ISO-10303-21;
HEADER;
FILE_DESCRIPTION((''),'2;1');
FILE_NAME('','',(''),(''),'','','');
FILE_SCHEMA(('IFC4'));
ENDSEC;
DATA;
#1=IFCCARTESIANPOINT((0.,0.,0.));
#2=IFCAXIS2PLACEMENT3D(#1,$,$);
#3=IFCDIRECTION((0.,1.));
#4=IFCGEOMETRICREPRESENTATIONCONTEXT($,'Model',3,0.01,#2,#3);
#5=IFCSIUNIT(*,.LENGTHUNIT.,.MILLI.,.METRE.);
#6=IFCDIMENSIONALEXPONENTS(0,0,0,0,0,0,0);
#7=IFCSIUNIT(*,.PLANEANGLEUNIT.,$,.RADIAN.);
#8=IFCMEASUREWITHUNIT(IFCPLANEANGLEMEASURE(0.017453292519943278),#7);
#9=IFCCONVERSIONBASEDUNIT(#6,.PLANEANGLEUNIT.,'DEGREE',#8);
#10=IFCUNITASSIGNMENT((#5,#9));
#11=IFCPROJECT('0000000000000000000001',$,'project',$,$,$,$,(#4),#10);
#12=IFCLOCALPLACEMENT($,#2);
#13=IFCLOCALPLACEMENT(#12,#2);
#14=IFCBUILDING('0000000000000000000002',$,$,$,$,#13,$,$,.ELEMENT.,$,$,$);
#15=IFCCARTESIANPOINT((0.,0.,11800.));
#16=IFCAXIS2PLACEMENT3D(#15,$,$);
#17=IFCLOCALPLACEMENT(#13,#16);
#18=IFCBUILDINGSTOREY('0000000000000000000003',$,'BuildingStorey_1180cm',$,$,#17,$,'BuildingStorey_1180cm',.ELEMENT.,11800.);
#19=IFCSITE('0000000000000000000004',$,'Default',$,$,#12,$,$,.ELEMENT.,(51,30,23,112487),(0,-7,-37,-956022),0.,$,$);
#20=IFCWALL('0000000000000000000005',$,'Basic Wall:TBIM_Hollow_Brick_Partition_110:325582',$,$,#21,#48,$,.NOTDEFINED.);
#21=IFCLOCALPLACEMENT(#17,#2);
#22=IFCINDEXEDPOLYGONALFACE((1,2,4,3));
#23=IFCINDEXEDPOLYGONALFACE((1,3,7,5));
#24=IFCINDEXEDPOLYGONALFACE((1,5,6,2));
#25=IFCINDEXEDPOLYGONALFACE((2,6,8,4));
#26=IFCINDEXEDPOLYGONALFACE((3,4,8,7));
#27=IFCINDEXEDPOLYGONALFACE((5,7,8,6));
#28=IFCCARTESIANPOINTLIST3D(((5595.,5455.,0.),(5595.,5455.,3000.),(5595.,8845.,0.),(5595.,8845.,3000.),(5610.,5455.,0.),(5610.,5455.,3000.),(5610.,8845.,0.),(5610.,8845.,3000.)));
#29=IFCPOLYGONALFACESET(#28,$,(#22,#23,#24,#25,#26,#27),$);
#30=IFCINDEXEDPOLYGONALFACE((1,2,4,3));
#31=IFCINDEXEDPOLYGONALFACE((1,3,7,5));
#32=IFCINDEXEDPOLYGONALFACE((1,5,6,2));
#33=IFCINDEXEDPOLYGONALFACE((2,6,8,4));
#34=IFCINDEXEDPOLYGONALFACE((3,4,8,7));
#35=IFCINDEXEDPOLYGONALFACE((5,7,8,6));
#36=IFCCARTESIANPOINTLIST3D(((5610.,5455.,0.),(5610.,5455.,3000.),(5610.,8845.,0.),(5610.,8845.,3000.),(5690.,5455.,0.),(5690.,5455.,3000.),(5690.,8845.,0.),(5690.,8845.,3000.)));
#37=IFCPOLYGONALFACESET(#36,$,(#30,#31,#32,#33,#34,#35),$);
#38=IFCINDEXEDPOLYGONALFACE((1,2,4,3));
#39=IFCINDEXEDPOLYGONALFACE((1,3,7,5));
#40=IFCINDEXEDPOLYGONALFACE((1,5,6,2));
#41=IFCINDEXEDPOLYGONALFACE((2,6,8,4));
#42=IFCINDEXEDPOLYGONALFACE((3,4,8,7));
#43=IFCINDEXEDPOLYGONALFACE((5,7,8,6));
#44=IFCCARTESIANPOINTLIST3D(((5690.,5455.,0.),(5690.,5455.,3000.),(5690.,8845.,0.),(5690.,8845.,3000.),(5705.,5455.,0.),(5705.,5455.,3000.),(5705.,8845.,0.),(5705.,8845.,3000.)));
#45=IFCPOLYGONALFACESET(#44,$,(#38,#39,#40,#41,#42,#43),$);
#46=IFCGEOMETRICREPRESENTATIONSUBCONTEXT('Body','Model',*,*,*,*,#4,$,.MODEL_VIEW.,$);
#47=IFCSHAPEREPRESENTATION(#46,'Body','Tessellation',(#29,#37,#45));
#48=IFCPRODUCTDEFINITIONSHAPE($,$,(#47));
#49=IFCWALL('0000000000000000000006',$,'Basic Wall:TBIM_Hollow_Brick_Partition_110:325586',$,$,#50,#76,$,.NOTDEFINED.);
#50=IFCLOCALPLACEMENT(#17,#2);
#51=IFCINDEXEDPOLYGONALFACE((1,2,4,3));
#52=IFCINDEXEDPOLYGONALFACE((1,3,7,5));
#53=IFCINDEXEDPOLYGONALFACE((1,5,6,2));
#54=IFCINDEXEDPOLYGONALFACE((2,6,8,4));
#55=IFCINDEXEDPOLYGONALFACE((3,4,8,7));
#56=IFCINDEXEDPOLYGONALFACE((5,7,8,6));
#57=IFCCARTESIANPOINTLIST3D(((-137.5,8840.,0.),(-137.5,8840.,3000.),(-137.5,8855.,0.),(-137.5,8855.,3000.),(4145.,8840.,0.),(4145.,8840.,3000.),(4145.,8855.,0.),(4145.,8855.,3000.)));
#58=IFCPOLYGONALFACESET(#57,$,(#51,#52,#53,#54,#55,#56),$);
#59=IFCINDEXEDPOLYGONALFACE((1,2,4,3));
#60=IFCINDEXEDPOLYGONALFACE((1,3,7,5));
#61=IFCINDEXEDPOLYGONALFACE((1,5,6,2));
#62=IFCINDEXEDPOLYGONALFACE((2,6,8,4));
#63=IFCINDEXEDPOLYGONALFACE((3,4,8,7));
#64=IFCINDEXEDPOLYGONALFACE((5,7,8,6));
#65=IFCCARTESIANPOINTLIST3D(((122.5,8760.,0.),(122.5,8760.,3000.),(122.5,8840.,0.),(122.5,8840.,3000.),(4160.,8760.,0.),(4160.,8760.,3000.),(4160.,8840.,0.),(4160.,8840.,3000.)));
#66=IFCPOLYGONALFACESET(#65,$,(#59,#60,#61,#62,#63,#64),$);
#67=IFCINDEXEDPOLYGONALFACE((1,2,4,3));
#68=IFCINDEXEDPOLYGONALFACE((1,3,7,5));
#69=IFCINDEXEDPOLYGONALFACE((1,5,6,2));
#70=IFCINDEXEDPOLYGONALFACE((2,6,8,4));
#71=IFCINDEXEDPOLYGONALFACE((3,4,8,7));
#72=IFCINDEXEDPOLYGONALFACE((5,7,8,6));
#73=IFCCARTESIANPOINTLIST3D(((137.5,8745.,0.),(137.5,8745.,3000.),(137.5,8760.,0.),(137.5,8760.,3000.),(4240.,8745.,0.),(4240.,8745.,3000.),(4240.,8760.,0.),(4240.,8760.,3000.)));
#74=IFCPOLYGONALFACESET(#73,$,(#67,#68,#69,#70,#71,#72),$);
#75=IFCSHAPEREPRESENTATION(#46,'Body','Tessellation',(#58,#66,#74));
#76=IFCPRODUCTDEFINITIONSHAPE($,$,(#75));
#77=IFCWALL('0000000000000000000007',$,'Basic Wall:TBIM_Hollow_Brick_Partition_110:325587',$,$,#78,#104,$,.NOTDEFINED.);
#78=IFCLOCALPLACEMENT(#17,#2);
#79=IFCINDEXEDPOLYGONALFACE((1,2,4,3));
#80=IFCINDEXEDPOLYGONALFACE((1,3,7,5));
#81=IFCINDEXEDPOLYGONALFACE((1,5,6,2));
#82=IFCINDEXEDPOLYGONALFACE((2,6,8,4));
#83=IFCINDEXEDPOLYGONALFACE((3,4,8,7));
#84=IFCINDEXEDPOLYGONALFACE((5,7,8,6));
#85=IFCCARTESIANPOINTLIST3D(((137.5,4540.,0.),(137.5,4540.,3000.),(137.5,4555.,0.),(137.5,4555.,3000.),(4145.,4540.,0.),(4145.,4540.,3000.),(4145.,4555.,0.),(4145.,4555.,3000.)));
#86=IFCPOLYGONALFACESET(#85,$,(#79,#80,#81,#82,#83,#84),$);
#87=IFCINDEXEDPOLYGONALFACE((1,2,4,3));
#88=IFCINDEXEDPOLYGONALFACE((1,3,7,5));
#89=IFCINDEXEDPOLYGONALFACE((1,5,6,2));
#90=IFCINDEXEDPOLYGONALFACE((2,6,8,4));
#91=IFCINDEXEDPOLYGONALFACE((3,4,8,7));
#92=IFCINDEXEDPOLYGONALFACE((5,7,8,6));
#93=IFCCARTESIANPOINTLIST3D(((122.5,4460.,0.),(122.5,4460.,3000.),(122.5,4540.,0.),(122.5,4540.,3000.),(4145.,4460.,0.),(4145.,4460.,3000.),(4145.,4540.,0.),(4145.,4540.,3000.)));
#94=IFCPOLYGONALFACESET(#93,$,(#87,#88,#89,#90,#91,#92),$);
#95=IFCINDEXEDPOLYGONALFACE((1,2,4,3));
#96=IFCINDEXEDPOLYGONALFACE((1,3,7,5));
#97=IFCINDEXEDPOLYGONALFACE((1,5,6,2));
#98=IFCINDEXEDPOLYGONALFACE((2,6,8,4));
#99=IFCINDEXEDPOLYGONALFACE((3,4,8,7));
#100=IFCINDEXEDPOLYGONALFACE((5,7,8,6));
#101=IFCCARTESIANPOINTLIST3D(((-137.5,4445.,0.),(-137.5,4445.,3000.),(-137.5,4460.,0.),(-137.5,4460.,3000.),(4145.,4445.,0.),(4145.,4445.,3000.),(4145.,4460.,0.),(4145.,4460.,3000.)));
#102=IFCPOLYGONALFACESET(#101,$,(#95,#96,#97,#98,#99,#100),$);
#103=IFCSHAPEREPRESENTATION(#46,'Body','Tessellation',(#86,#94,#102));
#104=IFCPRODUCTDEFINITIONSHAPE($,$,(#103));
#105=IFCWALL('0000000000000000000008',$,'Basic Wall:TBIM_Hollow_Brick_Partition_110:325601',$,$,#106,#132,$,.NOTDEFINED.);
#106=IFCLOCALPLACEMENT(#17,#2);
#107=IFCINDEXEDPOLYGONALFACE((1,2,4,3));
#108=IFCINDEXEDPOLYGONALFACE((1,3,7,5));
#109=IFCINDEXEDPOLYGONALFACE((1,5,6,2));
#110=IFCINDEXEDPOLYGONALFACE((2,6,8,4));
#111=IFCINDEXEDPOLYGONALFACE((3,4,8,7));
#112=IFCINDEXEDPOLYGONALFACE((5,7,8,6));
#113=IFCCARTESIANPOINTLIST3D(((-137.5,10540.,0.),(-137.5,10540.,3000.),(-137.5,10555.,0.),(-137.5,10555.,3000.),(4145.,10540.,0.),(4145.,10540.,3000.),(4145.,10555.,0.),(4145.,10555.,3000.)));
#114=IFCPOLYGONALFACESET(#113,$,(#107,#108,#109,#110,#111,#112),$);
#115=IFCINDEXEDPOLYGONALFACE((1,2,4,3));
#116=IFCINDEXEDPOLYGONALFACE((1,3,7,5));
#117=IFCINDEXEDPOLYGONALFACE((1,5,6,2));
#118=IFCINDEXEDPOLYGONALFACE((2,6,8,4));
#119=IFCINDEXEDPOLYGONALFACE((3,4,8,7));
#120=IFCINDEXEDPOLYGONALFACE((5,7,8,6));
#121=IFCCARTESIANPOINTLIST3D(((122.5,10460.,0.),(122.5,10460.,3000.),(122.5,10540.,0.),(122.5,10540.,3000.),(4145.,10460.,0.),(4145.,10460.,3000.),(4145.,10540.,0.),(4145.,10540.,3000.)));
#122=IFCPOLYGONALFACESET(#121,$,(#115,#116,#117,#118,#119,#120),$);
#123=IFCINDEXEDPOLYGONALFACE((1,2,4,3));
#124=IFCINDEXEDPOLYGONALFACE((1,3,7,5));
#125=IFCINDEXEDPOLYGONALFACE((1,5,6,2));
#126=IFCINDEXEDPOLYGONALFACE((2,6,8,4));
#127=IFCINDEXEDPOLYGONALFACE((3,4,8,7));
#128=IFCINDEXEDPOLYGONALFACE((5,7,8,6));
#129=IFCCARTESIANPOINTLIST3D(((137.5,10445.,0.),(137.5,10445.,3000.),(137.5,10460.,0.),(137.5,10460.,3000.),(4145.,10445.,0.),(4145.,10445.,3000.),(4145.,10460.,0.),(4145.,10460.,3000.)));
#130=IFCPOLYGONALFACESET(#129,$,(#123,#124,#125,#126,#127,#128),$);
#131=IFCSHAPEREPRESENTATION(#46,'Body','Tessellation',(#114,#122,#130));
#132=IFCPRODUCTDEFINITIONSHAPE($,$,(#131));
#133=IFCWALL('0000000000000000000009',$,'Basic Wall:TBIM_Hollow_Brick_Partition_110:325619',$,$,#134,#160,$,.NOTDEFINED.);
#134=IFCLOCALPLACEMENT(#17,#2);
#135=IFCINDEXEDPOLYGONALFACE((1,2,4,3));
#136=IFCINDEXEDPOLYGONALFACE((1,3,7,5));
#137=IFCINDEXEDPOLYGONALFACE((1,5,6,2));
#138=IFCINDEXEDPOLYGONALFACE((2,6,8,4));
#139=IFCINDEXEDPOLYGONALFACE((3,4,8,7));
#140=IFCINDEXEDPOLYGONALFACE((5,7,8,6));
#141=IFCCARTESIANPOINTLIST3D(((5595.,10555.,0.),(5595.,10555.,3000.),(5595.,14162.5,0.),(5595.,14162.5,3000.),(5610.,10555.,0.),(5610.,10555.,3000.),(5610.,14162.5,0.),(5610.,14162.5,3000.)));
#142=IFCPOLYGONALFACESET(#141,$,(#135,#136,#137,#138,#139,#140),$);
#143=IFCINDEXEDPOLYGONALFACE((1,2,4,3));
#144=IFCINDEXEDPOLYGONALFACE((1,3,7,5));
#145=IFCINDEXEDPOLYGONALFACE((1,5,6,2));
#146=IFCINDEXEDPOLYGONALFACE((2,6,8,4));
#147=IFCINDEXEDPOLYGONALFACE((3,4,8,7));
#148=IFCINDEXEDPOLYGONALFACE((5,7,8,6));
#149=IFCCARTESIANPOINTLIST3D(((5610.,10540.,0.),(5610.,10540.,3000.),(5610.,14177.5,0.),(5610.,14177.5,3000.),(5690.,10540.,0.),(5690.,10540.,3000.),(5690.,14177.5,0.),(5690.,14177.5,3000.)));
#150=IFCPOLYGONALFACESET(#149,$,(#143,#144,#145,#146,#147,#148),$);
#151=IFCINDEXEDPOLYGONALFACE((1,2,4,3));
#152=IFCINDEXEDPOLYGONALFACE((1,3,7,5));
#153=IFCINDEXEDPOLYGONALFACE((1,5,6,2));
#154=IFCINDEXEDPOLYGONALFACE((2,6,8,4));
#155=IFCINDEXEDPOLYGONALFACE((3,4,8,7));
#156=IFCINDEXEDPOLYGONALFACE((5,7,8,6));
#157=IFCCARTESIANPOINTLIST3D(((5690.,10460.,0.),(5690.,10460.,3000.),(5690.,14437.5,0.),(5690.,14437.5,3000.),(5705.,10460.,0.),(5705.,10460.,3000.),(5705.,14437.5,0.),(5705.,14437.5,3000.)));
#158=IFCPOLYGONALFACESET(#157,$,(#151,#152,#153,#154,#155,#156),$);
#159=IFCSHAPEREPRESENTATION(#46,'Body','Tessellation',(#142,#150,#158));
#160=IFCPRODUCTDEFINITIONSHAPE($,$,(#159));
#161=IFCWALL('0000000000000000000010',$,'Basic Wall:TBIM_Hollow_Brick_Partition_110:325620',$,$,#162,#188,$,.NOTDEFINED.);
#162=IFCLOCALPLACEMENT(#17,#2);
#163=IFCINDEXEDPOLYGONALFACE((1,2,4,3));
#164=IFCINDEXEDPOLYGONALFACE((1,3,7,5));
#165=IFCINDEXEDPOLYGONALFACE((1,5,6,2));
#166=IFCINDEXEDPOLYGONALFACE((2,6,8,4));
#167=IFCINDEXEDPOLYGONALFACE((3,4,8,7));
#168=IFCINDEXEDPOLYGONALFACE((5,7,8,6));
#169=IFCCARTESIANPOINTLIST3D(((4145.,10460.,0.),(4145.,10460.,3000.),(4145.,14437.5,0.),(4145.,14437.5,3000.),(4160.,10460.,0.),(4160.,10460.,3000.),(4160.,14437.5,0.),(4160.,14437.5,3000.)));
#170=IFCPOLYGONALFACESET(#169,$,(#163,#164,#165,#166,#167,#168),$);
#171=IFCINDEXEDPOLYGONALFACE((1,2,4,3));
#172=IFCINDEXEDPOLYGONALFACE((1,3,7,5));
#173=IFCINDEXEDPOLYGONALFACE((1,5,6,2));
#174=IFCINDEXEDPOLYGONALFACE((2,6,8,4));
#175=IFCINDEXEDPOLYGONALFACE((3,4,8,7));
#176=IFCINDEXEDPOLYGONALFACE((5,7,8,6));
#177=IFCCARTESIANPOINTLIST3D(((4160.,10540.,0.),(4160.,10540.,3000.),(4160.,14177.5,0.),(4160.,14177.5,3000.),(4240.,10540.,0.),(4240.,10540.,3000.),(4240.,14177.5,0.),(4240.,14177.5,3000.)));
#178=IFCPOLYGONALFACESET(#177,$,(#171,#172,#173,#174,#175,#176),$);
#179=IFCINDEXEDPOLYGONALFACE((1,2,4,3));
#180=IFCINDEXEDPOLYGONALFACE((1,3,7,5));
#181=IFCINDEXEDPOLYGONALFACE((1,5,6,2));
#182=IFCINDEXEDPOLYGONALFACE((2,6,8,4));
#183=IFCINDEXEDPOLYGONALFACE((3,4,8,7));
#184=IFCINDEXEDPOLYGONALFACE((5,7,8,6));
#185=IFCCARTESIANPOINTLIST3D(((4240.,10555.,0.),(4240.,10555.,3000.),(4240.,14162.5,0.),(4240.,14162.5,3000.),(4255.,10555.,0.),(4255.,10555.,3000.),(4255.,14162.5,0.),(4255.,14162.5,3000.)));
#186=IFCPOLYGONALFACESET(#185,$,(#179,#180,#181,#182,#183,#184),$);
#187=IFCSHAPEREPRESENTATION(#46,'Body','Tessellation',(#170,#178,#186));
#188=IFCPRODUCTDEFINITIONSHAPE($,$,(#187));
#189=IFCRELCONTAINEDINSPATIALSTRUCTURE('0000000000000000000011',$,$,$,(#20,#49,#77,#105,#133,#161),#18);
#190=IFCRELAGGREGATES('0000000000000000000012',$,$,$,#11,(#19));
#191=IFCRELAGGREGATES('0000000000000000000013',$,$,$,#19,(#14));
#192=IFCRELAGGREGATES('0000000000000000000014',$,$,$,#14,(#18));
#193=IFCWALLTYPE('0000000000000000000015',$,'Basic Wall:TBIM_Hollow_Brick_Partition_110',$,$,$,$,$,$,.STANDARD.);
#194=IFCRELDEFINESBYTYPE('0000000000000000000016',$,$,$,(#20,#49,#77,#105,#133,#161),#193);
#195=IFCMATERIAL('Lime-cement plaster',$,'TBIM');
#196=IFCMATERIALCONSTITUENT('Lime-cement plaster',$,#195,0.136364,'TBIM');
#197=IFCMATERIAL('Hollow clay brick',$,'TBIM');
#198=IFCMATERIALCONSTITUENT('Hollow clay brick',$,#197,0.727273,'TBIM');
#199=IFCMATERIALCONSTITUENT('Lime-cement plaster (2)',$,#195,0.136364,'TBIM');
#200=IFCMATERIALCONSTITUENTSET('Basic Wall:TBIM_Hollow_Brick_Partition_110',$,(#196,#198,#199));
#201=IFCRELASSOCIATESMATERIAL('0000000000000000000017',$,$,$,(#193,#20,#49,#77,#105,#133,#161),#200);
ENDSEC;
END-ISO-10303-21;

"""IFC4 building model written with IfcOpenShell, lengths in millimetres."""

from ifc_helpers import new_model, entity, si_unit, converted_unit, direction, frame, origin, place, context, subcontext, project, spatial, indexed_curve, outline, extrude, material, constituent, constituent_set, type_object, element, save


model = new_model("IFC4")

# Units and contexts
model_context = context("Model", 3, precision=0.01, world=origin(), true_north=direction((0.0, 1.0)))
body_context = subcontext(model_context, "Body", "Model", "MODEL_VIEW")
ifc_project = project(units=[si_unit("LENGTHUNIT", "METRE", prefix="MILLI"), converted_unit("PLANEANGLEUNIT", "DEGREE", entity("IfcPlaneAngleMeasure", 0.017453292519943278), si_unit("PLANEANGLEUNIT", "RADIAN"), dimensions=[0, 0, 0, 0, 0, 0, 0])], contexts=[model_context])

# Site, building, storey
site_placement = place(None, origin())
site = spatial("IfcSite", under=ifc_project, at=site_placement, Name="Default", CompositionType="ELEMENT", RefLatitude=(51, 30, 23, 112487), RefLongitude=(0, -7, -37, -956022), RefElevation=0.0)
building_placement = place(site_placement, origin())
building = spatial("IfcBuilding", under=site, at=building_placement, CompositionType="ELEMENT")
storey_placement = place(building_placement, frame((0.0, 0.0, 11800.0)))
storey = spatial("IfcBuildingStorey", under=building, at=storey_placement, Name="BuildingStorey_1180cm", LongName="BuildingStorey_1180cm", CompositionType="ELEMENT", Elevation=11800.0)

# Shared definitions
ifc_material_1 = material(Name="Lime-cement plaster", Category="TBIM")

# Shared definitions
ifc_material_2 = material(Name="Hollow clay brick", Category="TBIM")

# Shared definitions
ifc_constituent_1 = constituent(ifc_material_1, Name="Lime-cement plaster", Category="TBIM", fraction=0.136364)
ifc_constituent_2 = constituent(ifc_material_2, Name="Hollow clay brick", Category="TBIM", fraction=0.727273)
ifc_constituent_3 = constituent(ifc_material_1, Name="Lime-cement plaster (2)", Category="TBIM", fraction=0.136364)
ifc_constituent_set_1 = constituent_set(constituents=[ifc_constituent_1, ifc_constituent_2, ifc_constituent_3], Name="Basic Wall:TBIM_Hollow_Brick_Partition_110")
wall_type_1 = type_object("IfcWallType", Name="Basic Wall:TBIM_Hollow_Brick_Partition_110", PredefinedType="STANDARD", material=ifc_constituent_set_1)

# Wall
wall_1_placement = place(storey_placement, frame((5650.0, 5455.0, 0.0), z_axis=(0.0, 0.0, 1.0), x_axis=(0.0, 1.0, 0.0)))
element("IfcWall", 1, at=wall_1_placement, inside=storey, type_object=wall_type_1, material=ifc_constituent_set_1, Name="Basic Wall:TBIM_Hollow_Brick_Partition_110:325582", PredefinedType="NOTDEFINED", context=body_context, shape_type="SweptSolid", body=[
    extrude(outline(indexed_curve([(-7.5, -1695.0), (7.5, -1695.0), (7.5, 1695.0), (-7.5, 1695.0), (-7.5, -1695.0)], self_intersect=False)), frame((1695.0, 47.5, 0.0), z_axis=(0.0, 0.0, 1.0), x_axis=(0.0, -1.0, 0.0)), (0.0, 0.0, 1.0), 3000.0),
    extrude(outline(indexed_curve([(-1695.0, -40.0), (1695.0, -40.0), (1695.0, 40.0), (-1695.0, 40.0), (-1695.0, -40.0)], self_intersect=False)), frame((1695.0, 0.0, 0.0)), (0.0, 0.0, 1.0), 3000.0),
    extrude(outline(indexed_curve([(-7.5, -1695.0), (7.5, -1695.0), (7.5, 1695.0), (-7.5, 1695.0), (-7.5, -1695.0)], self_intersect=False)), frame((1695.0, -47.5, 0.0), z_axis=(0.0, 0.0, 1.0), x_axis=(0.0, 1.0, 0.0)), (0.0, 0.0, 1.0), 3000.0),
])

# Walls
wall_2_placement = place(storey_placement, frame((137.5, 8800.0, 0.0)))
element("IfcWall", 2, at=wall_2_placement, inside=storey, type_object=wall_type_1, material=ifc_constituent_set_1, Name="Basic Wall:TBIM_Hollow_Brick_Partition_110:325586", PredefinedType="NOTDEFINED", context=body_context, shape_type="SweptSolid", body=[
    extrude(outline(indexed_curve([(-7.5, -2141.2), (7.5, -2141.2), (7.5, 2141.2), (-7.5, 2141.2), (-7.5, -2141.2)], self_intersect=False)), frame((1866.2, 47.5, 0.0), z_axis=(0.0, 0.0, 1.0), x_axis=(0.0, -1.0, 0.0)), (0.0, 0.0, 1.0), 3000.0),
    extrude(outline(indexed_curve([(-2018.7, -40.0), (2018.7, -40.0), (2018.7, 40.0), (-2018.7, 40.0), (-2018.7, -40.0)], self_intersect=False)), frame((2003.7, 0.0, 0.0)), (0.0, 0.0, 1.0), 3000.0),
    extrude(outline(indexed_curve([(-7.5, -2051.2), (7.5, -2051.2), (7.5, 2051.2), (-7.5, 2051.2), (-7.5, -2051.2)], self_intersect=False)), frame((2051.2, -47.5, 0.0), z_axis=(0.0, 0.0, 1.0), x_axis=(0.0, 1.0, 0.0)), (0.0, 0.0, 1.0), 3000.0),
])
wall_3_placement = place(storey_placement, frame((137.5, 4500.0, 0.0)))
element("IfcWall", 3, at=wall_3_placement, inside=storey, type_object=wall_type_1, material=ifc_constituent_set_1, Name="Basic Wall:TBIM_Hollow_Brick_Partition_110:325587", PredefinedType="NOTDEFINED", context=body_context, shape_type="SweptSolid", body=[
    extrude(outline(indexed_curve([(-7.5, -2003.7), (7.5, -2003.7), (7.5, 2003.7), (-7.5, 2003.7), (-7.5, -2003.7)], self_intersect=False)), frame((2003.7, 47.5, 0.0), z_axis=(0.0, 0.0, 1.0), x_axis=(0.0, -1.0, 0.0)), (0.0, 0.0, 1.0), 3000.0),
    extrude(outline(indexed_curve([(-2011.2, -40.0), (2011.2, -40.0), (2011.2, 40.0), (-2011.2, 40.0), (-2011.2, -40.0)], self_intersect=False)), frame((1996.2, 0.0, 0.0)), (0.0, 0.0, 1.0), 3000.0),
    extrude(outline(indexed_curve([(-7.5, -2141.2), (7.5, -2141.2), (7.5, 2141.2), (-7.5, 2141.2), (-7.5, -2141.2)], self_intersect=False)), frame((1866.2, -47.5, 0.0), z_axis=(0.0, 0.0, 1.0), x_axis=(0.0, 1.0, 0.0)), (0.0, 0.0, 1.0), 3000.0),
])
wall_4_placement = place(storey_placement, frame((137.5, 10500.0, 0.0)))
element("IfcWall", 4, at=wall_4_placement, inside=storey, type_object=wall_type_1, material=ifc_constituent_set_1, Name="Basic Wall:TBIM_Hollow_Brick_Partition_110:325601", PredefinedType="NOTDEFINED", context=body_context, shape_type="SweptSolid", body=[
    extrude(outline(indexed_curve([(-7.5, -2141.2), (7.5, -2141.2), (7.5, 2141.2), (-7.5, 2141.2), (-7.5, -2141.2)], self_intersect=False)), frame((1866.2, 47.5, 0.0), z_axis=(0.0, 0.0, 1.0), x_axis=(0.0, -1.0, 0.0)), (0.0, 0.0, 1.0), 3000.0),
    extrude(outline(indexed_curve([(-2011.2, -40.0), (2011.2, -40.0), (2011.2, 40.0), (-2011.2, 40.0), (-2011.2, -40.0)], self_intersect=False)), frame((1996.2, 0.0, 0.0)), (0.0, 0.0, 1.0), 3000.0),
    extrude(outline(indexed_curve([(-7.5, -2003.7), (7.5, -2003.7), (7.5, 2003.7), (-7.5, 2003.7), (-7.5, -2003.7)], self_intersect=False)), frame((2003.7, -47.5, 0.0), z_axis=(0.0, 0.0, 1.0), x_axis=(0.0, 1.0, 0.0)), (0.0, 0.0, 1.0), 3000.0),
])
wall_5_placement = place(storey_placement, frame((5650.0, 10555.0, 0.0), z_axis=(0.0, 0.0, 1.0), x_axis=(0.0, 1.0, 0.0)))
element("IfcWall", 5, at=wall_5_placement, inside=storey, type_object=wall_type_1, material=ifc_constituent_set_1, Name="Basic Wall:TBIM_Hollow_Brick_Partition_110:325619", PredefinedType="NOTDEFINED", context=body_context, shape_type="SweptSolid", body=[
    extrude(outline(indexed_curve([(-7.5, -1803.7), (7.5, -1803.7), (7.5, 1803.8), (-7.5, 1803.8), (-7.5, -1803.7)], self_intersect=False)), frame((1803.7, 47.5, 0.0), z_axis=(0.0, 0.0, 1.0), x_axis=(0.0, -1.0, 0.0)), (0.0, 0.0, 1.0), 3000.0),
    extrude(outline(indexed_curve([(-1818.8, -40.0), (1818.8, -40.0), (1818.8, 40.0), (-1818.8, 40.0), (-1818.8, -40.0)], self_intersect=False)), frame((1803.7, 0.0, 0.0)), (0.0, 0.0, 1.0), 3000.0),
    extrude(outline(indexed_curve([(-7.5, -1988.8), (7.5, -1988.8), (7.5, 1988.8), (-7.5, 1988.8), (-7.5, -1988.8)], self_intersect=False)), frame((1893.8, -47.5, 0.0), z_axis=(0.0, 0.0, 1.0), x_axis=(0.0, 1.0, 0.0)), (0.0, 0.0, 1.0), 3000.0),
])
wall_6_placement = place(storey_placement, frame((4200.0, 10555.0, 0.0), z_axis=(0.0, 0.0, 1.0), x_axis=(0.0, 1.0, 0.0)))
element("IfcWall", 6, at=wall_6_placement, inside=storey, type_object=wall_type_1, material=ifc_constituent_set_1, Name="Basic Wall:TBIM_Hollow_Brick_Partition_110:325620", PredefinedType="NOTDEFINED", context=body_context, shape_type="SweptSolid", body=[
    extrude(outline(indexed_curve([(-7.5, -1988.8), (7.5, -1988.8), (7.5, 1988.8), (-7.5, 1988.8), (-7.5, -1988.8)], self_intersect=False)), frame((1893.8, 47.5, 0.0), z_axis=(0.0, 0.0, 1.0), x_axis=(0.0, -1.0, 0.0)), (0.0, 0.0, 1.0), 3000.0),
    extrude(outline(indexed_curve([(-1818.8, -40.0), (1818.8, -40.0), (1818.8, 40.0), (-1818.8, 40.0), (-1818.8, -40.0)], self_intersect=False)), frame((1803.7, 0.0, 0.0)), (0.0, 0.0, 1.0), 3000.0),
    extrude(outline(indexed_curve([(-7.5, -1803.8), (7.5, -1803.8), (7.5, 1803.7), (-7.5, 1803.7), (-7.5, -1803.8)], self_intersect=False)), frame((1803.7, -47.5, 0.0), z_axis=(0.0, 0.0, 1.0), x_axis=(0.0, 1.0, 0.0)), (0.0, 0.0, 1.0), 3000.0),
])

save(model, "model.ifc")
